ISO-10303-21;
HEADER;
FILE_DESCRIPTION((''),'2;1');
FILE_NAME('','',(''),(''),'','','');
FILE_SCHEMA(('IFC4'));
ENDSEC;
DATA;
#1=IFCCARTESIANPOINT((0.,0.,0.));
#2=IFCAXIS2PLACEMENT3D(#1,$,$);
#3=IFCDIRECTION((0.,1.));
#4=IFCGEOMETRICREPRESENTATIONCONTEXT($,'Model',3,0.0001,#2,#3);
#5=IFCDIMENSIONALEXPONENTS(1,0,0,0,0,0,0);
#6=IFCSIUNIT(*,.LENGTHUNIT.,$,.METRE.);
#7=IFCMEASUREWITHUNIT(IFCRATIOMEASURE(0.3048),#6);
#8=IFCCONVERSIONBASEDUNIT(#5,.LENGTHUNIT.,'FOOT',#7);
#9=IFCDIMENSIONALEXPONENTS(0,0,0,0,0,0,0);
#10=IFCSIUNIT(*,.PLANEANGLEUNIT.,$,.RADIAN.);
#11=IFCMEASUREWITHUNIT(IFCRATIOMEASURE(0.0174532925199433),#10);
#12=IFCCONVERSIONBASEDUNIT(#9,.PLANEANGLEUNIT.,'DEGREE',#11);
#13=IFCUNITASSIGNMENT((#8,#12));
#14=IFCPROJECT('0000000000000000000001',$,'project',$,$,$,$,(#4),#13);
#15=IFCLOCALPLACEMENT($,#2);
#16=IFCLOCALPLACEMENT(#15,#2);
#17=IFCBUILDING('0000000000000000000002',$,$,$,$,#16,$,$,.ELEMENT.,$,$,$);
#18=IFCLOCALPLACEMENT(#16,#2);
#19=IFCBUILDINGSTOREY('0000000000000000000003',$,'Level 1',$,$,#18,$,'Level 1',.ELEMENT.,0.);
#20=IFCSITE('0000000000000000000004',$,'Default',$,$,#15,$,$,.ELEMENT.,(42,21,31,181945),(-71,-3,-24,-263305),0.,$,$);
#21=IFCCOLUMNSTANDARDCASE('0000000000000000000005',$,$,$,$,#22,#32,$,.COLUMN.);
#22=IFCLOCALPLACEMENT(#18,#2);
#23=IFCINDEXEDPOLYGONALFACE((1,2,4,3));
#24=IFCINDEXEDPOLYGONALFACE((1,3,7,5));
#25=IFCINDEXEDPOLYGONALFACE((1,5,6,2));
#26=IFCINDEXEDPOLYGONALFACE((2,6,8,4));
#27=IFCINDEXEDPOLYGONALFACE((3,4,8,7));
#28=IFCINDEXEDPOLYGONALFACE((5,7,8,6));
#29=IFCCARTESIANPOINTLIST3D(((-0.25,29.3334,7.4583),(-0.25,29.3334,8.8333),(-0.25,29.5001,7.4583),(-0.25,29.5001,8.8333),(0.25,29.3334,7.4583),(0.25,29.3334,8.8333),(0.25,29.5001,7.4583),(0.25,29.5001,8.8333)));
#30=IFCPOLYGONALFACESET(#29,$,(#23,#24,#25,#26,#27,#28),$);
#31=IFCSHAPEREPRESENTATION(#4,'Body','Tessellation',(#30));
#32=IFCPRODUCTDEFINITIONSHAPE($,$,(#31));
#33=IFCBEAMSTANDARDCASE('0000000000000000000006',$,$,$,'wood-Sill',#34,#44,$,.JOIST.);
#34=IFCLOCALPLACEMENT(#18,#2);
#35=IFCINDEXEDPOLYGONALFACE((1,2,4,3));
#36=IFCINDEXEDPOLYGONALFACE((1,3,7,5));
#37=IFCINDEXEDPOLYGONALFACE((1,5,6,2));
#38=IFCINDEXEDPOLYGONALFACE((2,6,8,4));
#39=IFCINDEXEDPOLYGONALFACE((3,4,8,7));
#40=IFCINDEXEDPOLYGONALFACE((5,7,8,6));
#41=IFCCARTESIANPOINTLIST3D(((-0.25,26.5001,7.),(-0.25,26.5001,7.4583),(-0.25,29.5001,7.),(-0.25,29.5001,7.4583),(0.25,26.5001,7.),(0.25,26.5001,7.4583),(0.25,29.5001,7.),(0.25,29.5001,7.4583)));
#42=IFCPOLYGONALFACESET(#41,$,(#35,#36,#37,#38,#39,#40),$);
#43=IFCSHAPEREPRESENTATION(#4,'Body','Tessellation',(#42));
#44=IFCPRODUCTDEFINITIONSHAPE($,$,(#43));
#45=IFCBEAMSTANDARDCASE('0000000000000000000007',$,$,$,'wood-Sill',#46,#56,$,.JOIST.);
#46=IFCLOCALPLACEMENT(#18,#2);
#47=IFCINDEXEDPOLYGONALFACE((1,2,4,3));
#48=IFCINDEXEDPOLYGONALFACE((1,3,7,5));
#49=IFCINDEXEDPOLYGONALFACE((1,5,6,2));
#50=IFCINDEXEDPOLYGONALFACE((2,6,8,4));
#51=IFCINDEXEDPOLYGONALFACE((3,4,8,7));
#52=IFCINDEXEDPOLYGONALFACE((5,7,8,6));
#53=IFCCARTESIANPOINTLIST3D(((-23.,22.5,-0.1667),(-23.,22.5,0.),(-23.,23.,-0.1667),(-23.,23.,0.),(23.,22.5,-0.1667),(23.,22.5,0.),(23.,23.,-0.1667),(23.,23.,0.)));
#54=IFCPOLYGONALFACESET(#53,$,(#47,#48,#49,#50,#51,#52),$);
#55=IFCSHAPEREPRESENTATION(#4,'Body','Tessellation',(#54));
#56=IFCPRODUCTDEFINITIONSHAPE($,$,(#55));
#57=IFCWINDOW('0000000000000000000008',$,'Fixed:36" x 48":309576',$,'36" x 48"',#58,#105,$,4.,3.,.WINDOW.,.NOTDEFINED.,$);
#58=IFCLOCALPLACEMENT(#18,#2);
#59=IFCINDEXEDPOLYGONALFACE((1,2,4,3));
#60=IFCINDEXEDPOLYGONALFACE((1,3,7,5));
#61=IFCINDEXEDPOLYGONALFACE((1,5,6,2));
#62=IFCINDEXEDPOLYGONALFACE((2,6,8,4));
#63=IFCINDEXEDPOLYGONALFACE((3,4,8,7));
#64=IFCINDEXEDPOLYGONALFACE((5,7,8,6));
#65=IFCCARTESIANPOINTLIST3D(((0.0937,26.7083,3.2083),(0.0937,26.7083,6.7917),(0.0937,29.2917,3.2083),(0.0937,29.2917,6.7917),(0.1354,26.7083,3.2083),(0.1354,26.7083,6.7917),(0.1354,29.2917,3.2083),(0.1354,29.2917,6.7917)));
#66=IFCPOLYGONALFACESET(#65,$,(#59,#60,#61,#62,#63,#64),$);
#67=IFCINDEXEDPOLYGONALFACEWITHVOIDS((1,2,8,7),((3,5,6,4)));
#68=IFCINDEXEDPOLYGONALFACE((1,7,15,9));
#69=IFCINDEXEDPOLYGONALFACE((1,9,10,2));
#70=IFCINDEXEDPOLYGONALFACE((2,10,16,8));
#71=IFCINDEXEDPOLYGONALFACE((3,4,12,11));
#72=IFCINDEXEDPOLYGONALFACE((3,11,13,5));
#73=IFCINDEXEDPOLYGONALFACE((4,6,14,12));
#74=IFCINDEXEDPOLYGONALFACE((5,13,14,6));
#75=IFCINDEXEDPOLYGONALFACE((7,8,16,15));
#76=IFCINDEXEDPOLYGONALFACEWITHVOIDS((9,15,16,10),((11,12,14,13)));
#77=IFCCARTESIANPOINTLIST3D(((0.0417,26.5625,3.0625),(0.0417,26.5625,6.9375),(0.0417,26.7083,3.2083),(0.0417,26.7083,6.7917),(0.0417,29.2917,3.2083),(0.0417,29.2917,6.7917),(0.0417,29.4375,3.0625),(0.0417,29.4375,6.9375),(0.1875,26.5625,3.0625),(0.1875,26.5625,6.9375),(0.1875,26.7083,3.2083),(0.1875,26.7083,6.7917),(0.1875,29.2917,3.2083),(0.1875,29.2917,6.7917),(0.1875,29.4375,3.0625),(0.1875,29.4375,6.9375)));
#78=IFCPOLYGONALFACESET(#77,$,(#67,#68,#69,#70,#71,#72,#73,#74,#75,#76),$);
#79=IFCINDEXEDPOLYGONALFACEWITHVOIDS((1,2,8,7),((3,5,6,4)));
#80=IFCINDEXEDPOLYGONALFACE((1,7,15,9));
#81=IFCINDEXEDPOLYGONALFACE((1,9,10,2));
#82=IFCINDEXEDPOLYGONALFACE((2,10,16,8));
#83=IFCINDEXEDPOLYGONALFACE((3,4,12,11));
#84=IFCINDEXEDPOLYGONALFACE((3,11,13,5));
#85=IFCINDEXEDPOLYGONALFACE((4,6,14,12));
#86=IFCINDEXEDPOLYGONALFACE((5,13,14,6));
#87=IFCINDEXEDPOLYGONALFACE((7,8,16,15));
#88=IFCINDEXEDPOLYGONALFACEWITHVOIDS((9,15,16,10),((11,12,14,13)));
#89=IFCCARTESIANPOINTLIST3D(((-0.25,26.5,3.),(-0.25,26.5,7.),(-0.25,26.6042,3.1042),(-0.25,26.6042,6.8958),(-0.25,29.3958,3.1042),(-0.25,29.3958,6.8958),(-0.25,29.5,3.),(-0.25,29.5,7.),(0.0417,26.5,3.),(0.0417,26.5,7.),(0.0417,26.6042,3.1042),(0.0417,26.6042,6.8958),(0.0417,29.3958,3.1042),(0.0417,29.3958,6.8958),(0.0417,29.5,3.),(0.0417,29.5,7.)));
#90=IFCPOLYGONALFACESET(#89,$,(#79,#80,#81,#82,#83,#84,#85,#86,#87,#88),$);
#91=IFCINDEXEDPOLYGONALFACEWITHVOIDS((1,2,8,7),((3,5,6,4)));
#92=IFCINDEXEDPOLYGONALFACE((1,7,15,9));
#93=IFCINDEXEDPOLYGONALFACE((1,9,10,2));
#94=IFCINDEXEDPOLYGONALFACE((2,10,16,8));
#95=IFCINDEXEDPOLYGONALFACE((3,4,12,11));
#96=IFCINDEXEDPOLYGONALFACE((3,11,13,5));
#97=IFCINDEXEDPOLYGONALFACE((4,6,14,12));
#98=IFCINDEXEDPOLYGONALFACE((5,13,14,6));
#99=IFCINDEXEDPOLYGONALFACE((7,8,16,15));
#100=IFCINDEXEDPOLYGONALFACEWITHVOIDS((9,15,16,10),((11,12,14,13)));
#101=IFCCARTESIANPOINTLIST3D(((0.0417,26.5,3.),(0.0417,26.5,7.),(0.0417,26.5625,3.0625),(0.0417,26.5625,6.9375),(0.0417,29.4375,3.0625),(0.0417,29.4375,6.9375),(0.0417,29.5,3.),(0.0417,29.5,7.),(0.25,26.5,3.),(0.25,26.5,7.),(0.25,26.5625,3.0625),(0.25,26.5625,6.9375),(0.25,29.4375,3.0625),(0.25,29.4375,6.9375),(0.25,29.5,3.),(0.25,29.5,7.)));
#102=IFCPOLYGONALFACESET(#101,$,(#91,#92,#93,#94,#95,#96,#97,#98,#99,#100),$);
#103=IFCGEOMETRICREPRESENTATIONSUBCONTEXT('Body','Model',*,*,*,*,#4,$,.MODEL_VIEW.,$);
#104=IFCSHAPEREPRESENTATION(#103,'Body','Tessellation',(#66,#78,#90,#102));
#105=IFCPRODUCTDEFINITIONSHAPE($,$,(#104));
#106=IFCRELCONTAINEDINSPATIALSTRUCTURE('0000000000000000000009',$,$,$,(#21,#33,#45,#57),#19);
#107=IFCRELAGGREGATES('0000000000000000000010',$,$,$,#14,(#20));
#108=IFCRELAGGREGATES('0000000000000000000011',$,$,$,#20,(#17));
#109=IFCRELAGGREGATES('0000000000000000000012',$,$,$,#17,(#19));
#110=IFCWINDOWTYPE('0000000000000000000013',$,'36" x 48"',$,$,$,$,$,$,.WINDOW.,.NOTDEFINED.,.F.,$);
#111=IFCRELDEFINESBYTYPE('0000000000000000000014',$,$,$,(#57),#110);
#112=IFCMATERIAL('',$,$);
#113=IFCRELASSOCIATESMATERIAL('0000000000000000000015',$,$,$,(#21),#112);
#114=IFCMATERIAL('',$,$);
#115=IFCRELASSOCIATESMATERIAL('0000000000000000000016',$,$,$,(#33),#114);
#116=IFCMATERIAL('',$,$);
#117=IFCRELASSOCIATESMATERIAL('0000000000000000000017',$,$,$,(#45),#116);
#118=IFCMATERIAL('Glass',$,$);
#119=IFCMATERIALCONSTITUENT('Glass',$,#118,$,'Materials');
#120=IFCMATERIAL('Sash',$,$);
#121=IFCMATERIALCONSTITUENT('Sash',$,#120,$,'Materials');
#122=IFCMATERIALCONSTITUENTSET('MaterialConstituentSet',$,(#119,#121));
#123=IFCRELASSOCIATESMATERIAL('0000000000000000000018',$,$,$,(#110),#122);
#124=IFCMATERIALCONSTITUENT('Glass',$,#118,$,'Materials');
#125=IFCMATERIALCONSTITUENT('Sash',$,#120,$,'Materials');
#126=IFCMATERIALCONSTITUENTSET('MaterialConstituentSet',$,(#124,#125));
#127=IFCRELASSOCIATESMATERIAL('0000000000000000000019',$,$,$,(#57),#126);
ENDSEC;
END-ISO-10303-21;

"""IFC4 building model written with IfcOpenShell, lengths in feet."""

from ifc_helpers import new_model, entity, si_unit, converted_unit, direction, frame, frame_2d, origin, place, context, subcontext, project, spatial, polyline, rectangle, outline, extrude, source, transform, mapped, material, constituent, constituent_set, type_object, type_shapes, element, save


model = new_model("IFC4")

# Units and contexts
model_context = context("Model", 3, precision=0.0001, world=origin(), true_north=direction((0.0, 1.0)))
body_context = subcontext(model_context, "Body", "Model", "MODEL_VIEW")
ifc_project = project(units=[converted_unit("LENGTHUNIT", "FOOT", entity("IfcRatioMeasure", 0.3048), si_unit("LENGTHUNIT", "METRE"), dimensions=[1, 0, 0, 0, 0, 0, 0]), converted_unit("PLANEANGLEUNIT", "DEGREE", entity("IfcRatioMeasure", 0.0174532925199433), si_unit("PLANEANGLEUNIT", "RADIAN"), dimensions=[0, 0, 0, 0, 0, 0, 0])], contexts=[model_context])

# Site, building, storey
site_placement = place(None, origin())
site = spatial("IfcSite", under=ifc_project, at=site_placement, Name="Default", CompositionType="ELEMENT", RefLatitude=(42, 21, 31, 181945), RefLongitude=(-71, -3, -24, -263305), RefElevation=0.0)
building_placement = place(site_placement, origin())
building = spatial("IfcBuilding", under=site, at=building_placement, CompositionType="ELEMENT")
storey_placement = place(building_placement, origin())
storey = spatial("IfcBuildingStorey", under=building, at=storey_placement, Name="Level 1", LongName="Level 1", CompositionType="ELEMENT", Elevation=0.0)

# Column
placement_1 = place(storey_placement, frame((0.0, -0.25, 0.0), z_axis=(0.0, 0.0, 1.0), x_axis=(0.0, 1.0, 0.0)))
ifc_material_1 = material(Name="")
for number, where, z_axis, x_axis in (
    (1, (29.6667, 0.0, 7.4583), (0.0, 0.0, 1.0), (1.0, 0.0, 0.0)),
):
    element("IfcColumnStandardCase", number, at=place(placement_1, frame(where, z_axis=z_axis, x_axis=x_axis)), inside=storey, material=ifc_material_1, PredefinedType="COLUMN", context=model_context, shape_type="SweptSolid", body=[
        extrude(rectangle(XDim=0.1667, YDim=0.5), origin(), (0.0, 0.0, 1.0), 1.375),
    ])

# Beams
ifc_material_2 = material(Name="")
beam_1_placement = place(placement_1, frame((28.2501, 0.0, 7.0), z_axis=(0.0, 0.0, 1.0), x_axis=(-1.0, 0.0, 0.0)))
element("IfcBeamStandardCase", 2, at=beam_1_placement, inside=storey, material=ifc_material_2, ObjectType="wood-Sill", PredefinedType="JOIST", context=model_context, shape_type="SweptSolid", body=[
    extrude(rectangle(XDim=3.0, YDim=0.5), origin(), (0.0, 0.0, 1.0), 0.4583),
])
ifc_material_3 = material(Name="")
beam_2_placement = place(placement_1, frame((23.0, 0.0, -0.1667), z_axis=(0.0, 0.0, 1.0), x_axis=(0.0, 1.0, 0.0)))
element("IfcBeamStandardCase", 3, at=beam_2_placement, inside=storey, material=ifc_material_3, ObjectType="wood-Sill", PredefinedType="JOIST", context=model_context, shape_type="SweptSolid", body=[
    extrude(rectangle(XDim=46.0, YDim=0.5), origin(), (0.0, 0.0, 1.0), 0.1667),
])

# Window
ifc_material_4 = material(Name="Glass")
ifc_constituent_1 = constituent(ifc_material_4, Name="Glass", Category="Materials")
ifc_material_5 = material(Name="Sash")
ifc_constituent_2 = constituent(ifc_material_5, Name="Sash", Category="Materials")
ifc_constituent_set_1 = constituent_set(constituents=[ifc_constituent_1, ifc_constituent_2], Name="MaterialConstituentSet")
ifc_constituent_3 = constituent(ifc_material_4, Name="Glass", Category="Materials")
ifc_constituent_4 = constituent(ifc_material_5, Name="Sash", Category="Materials")
ifc_constituent_set_2 = constituent_set(constituents=[ifc_constituent_3, ifc_constituent_4], Name="MaterialConstituentSet")
window_type = type_object("IfcWindowType", Name="36\" x 48\"", ParameterTakesPrecedence=False, PartitioningType="NOTDEFINED", PredefinedType="WINDOW", material=ifc_constituent_set_2)
shared_shape = source(origin(), body_context, "Body", "SweptSolid", [
    extrude(rectangle(XDim=0.0417, YDim=2.5833, at=frame_2d((0.0, 0.0), x_axis=(1.0, 0.0))), frame((1.5, 0.3646, 0.2083), z_axis=(0.0, 0.0, 1.0), x_axis=(0.0, 1.0, 0.0)), (0.0, 0.0, 1.0), 3.5833),
    extrude(outline(polyline([(-1.4375, -1.9375), (1.4375, -1.9375), (1.4375, 1.9375), (-1.4375, 1.9375), (-1.4375, -1.9375)]), holes=[polyline([(-1.2917, -1.7917), (-1.2917, 1.7917), (1.2917, 1.7917), (1.2917, -1.7917), (-1.2917, -1.7917)])]), frame((1.5, 0.2917, 2.0), z_axis=(0.0, 1.0, 0.0), x_axis=(1.0, 0.0, 0.0)), (0.0, 0.0, 1.0), 0.1458),
    extrude(outline(polyline([(-1.5, -2.0), (1.5, -2.0), (1.5, 2.0), (-1.5, 2.0), (-1.5, -2.0)]), holes=[polyline([(-1.3958, -1.8958), (-1.3958, 1.8958), (1.3958, 1.8958), (1.3958, -1.8958), (-1.3958, -1.8958)])]), frame((1.5, 0.0, 2.0), z_axis=(0.0, 1.0, 0.0), x_axis=(1.0, 0.0, 0.0)), (0.0, 0.0, 1.0), 0.2917),
    extrude(outline(polyline([(-2.0, -1.5), (2.0, -1.5), (2.0, 1.5), (-2.0, 1.5), (-2.0, -1.5)]), holes=[polyline([(-1.9375, -1.4375), (-1.9375, 1.4375), (1.9375, 1.4375), (1.9375, -1.4375), (-1.9375, -1.4375)])]), frame((1.5, 0.2917, 2.0), z_axis=(0.0, 1.0, 0.0), x_axis=(0.0, 0.0, -1.0)), (0.0, 0.0, 1.0), 0.2083),
])
type_shapes(window_type, [shared_shape])
placement_2 = place(placement_1, frame((29.75, 0.25, 3.0)))
window_placement = place(placement_2, frame((0.0, 0.0, 0.0), z_axis=(0.0, 0.0, 1.0), x_axis=(-1.0, 0.0, 0.0)))
element("IfcWindow", 4, at=window_placement, inside=storey, type_object=window_type, material=ifc_constituent_set_1, Name="Fixed:36\" x 48\":309576", ObjectType="36\" x 48\"", OverallHeight=4.0, OverallWidth=3.0, PartitioningType="NOTDEFINED", PredefinedType="WINDOW", context=body_context, shape_type="MappedRepresentation", body=[
    mapped(shared_shape, transform((0.0, 0.0, 0.0), scale=1.0)),
])

save(model, "model.ifc")
